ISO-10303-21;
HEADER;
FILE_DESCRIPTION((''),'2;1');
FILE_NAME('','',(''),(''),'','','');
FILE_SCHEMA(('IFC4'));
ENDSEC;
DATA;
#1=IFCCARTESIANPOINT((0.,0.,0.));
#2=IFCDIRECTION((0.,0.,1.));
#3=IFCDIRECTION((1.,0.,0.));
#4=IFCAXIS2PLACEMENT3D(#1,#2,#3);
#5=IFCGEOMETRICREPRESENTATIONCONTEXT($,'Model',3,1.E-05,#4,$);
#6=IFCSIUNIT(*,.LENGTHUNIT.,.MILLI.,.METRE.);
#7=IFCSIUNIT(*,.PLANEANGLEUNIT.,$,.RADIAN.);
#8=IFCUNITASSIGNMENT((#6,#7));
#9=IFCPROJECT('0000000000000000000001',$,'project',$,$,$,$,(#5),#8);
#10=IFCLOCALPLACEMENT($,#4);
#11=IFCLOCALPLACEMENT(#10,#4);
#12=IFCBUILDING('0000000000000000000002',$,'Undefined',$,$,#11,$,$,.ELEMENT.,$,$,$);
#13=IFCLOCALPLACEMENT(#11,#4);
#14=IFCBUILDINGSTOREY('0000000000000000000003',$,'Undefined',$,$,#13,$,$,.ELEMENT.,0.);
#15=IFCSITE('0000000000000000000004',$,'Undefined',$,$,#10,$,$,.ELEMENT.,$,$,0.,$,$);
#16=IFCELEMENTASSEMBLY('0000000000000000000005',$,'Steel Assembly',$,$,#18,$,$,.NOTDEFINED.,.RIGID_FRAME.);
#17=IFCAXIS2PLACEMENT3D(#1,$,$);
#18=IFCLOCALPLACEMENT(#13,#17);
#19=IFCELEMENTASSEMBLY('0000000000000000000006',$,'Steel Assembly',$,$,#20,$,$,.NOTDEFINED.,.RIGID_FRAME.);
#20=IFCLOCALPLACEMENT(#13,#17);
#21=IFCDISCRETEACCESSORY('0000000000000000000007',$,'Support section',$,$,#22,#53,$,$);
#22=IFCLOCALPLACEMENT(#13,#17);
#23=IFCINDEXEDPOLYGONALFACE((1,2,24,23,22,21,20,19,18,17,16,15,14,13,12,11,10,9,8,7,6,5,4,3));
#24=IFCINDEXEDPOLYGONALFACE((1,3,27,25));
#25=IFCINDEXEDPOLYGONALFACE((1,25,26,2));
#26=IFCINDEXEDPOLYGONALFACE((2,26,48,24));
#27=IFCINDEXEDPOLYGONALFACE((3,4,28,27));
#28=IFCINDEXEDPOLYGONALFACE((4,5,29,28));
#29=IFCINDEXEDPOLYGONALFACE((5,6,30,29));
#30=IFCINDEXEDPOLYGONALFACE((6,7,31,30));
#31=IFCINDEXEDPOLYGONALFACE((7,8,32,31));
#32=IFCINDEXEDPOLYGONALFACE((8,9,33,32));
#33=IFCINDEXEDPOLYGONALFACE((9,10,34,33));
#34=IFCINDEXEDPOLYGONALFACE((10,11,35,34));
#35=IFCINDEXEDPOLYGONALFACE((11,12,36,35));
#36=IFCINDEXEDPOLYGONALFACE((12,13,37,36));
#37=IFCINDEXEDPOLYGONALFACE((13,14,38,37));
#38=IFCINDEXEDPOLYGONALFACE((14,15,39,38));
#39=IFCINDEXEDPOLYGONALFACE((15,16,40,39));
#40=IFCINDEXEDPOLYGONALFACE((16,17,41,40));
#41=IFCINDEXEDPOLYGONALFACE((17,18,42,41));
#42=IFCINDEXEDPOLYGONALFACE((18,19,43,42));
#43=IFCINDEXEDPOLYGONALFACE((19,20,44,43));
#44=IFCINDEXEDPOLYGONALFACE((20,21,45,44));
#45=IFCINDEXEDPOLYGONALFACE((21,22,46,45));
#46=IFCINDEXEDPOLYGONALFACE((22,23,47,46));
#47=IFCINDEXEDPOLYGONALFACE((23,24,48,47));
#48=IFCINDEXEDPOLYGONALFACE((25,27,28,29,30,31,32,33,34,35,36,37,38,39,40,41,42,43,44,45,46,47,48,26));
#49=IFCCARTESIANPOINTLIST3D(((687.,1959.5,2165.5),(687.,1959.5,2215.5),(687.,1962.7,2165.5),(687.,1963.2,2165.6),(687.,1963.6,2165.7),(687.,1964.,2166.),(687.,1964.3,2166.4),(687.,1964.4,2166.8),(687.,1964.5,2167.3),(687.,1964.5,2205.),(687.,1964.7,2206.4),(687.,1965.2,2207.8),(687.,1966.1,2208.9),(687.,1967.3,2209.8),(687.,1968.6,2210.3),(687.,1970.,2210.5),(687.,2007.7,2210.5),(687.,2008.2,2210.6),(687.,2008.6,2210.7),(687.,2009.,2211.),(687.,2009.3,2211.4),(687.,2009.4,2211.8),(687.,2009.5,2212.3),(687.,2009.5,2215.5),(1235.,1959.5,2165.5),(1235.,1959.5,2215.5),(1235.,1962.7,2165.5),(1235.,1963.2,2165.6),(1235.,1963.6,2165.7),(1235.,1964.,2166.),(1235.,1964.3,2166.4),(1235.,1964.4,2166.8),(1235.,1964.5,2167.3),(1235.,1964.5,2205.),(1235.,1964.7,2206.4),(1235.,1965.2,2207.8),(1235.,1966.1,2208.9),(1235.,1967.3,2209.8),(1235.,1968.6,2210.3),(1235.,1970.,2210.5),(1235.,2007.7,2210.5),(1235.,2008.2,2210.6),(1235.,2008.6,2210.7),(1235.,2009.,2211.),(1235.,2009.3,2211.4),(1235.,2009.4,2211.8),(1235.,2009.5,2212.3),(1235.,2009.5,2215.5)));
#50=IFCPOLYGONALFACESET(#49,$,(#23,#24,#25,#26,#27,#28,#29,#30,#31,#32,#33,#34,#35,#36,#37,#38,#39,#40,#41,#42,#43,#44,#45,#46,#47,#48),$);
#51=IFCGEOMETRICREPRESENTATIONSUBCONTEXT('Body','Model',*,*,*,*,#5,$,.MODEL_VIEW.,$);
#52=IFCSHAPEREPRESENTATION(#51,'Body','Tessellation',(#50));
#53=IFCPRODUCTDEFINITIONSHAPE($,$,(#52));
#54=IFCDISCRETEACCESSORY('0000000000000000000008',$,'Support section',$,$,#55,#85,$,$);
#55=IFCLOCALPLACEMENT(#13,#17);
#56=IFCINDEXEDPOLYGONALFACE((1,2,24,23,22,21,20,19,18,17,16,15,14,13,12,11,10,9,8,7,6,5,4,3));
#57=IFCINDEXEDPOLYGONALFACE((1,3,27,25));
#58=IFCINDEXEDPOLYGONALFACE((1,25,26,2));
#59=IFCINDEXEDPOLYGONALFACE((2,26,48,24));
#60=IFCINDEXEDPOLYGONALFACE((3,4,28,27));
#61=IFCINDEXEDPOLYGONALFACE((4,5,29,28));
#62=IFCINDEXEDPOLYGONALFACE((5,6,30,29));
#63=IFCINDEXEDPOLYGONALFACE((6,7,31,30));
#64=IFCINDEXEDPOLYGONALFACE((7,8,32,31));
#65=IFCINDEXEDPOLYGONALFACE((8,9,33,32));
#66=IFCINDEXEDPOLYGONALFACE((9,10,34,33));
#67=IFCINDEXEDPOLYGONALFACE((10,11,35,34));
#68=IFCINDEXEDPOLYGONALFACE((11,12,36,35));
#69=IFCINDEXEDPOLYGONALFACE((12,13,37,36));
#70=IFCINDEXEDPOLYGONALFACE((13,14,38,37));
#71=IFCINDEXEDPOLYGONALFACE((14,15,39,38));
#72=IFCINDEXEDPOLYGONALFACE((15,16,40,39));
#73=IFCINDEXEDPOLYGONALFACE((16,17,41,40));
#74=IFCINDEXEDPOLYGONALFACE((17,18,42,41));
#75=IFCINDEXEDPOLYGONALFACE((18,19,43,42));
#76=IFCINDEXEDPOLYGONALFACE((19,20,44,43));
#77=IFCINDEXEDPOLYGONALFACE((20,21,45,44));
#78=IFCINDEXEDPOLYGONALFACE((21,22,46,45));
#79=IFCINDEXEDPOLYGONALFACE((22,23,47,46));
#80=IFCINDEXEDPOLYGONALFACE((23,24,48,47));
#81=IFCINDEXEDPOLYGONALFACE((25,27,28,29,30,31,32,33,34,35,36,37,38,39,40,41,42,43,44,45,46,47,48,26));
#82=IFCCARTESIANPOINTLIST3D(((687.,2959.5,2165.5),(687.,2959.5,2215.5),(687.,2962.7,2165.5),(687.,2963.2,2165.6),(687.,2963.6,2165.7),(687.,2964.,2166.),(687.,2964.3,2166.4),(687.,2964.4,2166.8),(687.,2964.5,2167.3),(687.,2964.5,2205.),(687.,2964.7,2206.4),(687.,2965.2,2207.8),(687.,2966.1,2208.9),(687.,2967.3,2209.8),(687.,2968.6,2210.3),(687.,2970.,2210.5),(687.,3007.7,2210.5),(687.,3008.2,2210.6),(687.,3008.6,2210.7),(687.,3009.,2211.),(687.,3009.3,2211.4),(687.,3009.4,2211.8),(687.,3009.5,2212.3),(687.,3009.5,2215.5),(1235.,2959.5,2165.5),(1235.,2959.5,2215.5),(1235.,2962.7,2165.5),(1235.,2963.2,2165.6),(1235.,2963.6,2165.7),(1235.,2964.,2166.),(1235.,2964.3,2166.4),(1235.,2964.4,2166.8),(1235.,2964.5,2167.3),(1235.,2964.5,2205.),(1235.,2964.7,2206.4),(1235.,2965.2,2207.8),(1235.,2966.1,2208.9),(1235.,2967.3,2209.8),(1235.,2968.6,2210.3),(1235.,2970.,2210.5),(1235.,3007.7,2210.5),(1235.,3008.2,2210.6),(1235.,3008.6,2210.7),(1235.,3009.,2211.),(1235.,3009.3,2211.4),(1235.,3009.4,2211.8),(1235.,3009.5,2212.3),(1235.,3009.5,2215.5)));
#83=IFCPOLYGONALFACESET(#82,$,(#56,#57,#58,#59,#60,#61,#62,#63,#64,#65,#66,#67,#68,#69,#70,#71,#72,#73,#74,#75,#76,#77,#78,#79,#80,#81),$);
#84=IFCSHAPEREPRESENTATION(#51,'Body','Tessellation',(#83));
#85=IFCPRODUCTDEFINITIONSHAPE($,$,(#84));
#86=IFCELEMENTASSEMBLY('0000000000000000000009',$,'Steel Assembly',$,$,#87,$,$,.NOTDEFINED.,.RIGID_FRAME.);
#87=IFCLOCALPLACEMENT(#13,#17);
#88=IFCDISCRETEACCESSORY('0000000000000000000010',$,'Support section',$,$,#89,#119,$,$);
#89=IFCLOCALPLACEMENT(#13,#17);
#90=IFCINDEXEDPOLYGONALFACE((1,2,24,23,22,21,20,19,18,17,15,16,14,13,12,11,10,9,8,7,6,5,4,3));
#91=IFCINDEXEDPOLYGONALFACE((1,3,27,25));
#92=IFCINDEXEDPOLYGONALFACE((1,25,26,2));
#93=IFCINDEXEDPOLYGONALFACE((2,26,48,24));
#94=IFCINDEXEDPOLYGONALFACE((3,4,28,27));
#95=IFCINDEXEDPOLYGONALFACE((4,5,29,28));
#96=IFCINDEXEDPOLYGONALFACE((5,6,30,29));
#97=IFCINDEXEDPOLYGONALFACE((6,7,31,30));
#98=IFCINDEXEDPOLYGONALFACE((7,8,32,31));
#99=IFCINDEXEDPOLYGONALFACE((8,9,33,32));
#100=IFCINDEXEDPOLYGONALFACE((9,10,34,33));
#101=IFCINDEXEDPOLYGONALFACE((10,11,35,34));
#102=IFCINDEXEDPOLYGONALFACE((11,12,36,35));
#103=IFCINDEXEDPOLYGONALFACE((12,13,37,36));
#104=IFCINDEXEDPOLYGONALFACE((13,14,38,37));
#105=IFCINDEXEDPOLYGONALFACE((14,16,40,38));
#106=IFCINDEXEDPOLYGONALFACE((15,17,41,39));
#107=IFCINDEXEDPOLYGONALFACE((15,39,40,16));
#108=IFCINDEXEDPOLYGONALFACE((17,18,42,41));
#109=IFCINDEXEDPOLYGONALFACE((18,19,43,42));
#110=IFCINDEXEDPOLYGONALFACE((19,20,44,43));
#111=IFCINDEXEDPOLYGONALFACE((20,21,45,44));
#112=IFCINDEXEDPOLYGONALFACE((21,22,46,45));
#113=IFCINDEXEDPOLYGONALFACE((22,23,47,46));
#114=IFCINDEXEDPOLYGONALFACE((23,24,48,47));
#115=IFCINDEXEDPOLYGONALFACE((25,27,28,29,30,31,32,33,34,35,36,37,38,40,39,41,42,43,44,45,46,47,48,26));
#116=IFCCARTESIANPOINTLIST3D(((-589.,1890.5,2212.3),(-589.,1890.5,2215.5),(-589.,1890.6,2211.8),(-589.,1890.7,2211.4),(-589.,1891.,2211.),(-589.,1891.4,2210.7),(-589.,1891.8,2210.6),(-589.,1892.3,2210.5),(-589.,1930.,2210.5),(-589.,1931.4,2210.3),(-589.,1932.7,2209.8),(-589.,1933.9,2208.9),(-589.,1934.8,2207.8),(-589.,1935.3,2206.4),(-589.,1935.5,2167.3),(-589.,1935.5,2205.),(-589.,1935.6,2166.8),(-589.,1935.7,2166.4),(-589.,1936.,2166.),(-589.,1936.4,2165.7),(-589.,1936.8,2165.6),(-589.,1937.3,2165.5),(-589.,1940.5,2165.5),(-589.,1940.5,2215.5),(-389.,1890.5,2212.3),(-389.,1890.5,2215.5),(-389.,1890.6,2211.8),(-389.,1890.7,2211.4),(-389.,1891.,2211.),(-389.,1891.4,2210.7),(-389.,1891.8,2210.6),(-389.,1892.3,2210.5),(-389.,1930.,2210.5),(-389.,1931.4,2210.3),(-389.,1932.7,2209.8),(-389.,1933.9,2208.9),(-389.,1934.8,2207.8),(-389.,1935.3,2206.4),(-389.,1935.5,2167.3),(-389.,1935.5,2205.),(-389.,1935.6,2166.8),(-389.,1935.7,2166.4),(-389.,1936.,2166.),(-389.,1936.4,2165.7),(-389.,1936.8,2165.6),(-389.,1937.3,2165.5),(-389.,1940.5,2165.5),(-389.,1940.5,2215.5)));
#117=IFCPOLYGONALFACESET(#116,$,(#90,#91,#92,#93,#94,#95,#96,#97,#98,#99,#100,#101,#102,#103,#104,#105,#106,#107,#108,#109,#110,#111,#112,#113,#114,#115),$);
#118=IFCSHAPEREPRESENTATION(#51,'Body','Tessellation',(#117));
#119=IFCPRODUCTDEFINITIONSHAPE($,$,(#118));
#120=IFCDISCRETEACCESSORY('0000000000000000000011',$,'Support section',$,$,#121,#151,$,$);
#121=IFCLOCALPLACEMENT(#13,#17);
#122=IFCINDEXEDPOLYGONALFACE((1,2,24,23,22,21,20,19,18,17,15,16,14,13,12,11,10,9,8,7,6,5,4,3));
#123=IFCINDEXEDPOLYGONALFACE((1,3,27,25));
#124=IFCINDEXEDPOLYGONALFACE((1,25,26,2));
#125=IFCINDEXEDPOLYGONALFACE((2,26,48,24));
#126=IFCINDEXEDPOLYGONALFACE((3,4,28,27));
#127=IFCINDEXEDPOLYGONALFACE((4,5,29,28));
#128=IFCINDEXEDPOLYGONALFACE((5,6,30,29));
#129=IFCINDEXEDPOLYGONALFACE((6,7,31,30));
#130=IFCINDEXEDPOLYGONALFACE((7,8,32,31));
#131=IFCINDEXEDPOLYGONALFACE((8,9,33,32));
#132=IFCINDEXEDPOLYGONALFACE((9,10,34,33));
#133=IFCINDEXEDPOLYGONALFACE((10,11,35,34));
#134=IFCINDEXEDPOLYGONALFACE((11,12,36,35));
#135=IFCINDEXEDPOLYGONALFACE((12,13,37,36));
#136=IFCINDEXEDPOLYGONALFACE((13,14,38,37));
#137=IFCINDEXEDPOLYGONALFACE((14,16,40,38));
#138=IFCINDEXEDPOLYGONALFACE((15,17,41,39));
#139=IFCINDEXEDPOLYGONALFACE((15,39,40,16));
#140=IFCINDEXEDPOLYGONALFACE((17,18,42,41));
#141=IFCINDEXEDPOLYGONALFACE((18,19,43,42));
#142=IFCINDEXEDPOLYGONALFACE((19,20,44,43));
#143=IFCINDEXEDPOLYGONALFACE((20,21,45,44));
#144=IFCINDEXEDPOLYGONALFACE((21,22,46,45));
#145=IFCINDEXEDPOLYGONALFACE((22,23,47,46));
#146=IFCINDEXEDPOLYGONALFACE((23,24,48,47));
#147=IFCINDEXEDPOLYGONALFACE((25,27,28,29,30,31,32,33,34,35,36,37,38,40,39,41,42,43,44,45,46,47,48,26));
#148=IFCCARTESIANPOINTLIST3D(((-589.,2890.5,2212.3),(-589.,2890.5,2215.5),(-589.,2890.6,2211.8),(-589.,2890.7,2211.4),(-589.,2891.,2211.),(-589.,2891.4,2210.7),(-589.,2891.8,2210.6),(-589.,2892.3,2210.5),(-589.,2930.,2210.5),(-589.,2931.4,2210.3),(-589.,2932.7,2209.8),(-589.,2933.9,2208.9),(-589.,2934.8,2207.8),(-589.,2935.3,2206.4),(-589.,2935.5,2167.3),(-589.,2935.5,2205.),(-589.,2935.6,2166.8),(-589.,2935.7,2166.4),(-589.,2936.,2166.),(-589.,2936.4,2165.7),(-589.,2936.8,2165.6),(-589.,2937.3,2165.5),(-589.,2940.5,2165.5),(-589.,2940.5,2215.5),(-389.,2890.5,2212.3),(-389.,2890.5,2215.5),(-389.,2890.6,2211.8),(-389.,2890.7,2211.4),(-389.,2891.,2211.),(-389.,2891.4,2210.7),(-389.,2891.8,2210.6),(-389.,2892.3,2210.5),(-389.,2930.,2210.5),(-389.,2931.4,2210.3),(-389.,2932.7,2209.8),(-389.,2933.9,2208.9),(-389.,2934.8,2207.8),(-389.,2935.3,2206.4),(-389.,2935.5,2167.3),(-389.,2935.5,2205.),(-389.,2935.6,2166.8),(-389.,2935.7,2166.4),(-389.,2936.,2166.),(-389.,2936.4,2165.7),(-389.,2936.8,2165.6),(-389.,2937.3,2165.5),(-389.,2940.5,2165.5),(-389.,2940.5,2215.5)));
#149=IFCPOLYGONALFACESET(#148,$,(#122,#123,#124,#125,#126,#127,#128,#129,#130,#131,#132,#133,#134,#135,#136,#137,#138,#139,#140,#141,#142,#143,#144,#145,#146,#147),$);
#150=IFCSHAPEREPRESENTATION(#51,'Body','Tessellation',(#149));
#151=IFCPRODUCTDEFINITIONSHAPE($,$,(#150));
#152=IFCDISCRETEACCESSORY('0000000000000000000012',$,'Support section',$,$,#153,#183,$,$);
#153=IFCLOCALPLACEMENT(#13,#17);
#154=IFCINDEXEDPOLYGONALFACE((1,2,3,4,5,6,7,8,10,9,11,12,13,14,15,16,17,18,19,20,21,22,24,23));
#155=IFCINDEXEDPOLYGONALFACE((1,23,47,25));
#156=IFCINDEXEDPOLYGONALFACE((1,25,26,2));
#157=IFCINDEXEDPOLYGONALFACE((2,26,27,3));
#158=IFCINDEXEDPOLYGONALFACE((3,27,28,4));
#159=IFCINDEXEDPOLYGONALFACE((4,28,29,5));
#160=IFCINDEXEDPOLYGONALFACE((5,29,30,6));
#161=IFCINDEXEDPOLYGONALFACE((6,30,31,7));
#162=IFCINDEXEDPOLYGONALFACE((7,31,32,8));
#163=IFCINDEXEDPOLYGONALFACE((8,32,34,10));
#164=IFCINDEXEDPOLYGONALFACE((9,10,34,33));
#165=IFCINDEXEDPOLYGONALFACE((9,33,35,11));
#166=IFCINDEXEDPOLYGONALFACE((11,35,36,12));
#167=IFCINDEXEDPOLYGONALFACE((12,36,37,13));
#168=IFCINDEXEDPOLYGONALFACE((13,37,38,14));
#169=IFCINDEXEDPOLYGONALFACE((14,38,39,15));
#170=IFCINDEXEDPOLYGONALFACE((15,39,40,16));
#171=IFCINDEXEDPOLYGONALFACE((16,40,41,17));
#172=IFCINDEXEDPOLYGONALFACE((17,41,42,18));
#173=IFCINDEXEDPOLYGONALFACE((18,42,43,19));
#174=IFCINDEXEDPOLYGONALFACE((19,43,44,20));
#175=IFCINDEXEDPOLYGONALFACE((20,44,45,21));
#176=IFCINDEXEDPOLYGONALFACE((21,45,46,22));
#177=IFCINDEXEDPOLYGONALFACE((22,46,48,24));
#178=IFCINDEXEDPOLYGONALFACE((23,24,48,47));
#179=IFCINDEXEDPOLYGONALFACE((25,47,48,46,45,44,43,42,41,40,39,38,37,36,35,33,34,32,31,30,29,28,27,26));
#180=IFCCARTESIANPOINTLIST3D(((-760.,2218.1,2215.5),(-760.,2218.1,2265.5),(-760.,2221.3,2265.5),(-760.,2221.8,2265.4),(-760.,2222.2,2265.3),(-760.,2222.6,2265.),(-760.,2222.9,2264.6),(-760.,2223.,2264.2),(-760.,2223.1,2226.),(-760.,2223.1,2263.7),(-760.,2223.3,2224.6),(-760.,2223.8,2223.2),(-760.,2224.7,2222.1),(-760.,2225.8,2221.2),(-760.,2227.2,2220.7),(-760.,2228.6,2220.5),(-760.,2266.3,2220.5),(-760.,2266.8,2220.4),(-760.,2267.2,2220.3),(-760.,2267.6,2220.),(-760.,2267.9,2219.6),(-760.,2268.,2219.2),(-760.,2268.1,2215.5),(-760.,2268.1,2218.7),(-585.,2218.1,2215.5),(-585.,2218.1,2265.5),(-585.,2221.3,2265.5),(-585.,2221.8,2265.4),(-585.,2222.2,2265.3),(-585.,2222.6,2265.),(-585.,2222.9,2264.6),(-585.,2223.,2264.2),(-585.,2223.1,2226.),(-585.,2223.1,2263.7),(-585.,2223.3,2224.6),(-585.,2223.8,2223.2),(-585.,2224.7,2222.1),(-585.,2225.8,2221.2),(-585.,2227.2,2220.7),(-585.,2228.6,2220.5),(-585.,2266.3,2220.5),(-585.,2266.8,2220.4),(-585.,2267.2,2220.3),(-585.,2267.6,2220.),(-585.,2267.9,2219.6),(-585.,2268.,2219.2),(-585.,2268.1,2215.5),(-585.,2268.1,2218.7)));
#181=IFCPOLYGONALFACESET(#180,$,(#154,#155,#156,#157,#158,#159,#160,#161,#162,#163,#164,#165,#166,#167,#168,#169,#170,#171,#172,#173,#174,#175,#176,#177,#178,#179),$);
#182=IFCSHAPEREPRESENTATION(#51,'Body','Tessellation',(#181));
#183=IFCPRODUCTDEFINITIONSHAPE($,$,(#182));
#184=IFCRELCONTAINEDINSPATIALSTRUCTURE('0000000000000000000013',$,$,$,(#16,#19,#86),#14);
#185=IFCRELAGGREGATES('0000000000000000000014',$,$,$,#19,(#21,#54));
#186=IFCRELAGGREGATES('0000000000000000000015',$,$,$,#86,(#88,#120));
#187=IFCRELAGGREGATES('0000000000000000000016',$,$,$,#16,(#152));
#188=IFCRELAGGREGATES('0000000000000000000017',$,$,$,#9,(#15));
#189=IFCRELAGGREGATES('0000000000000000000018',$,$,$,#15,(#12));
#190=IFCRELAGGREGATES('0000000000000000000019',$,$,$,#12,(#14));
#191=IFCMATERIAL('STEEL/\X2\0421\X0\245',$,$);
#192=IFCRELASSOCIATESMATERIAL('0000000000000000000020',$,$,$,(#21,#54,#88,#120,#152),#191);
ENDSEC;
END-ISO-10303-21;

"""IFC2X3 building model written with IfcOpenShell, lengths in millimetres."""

from ifc_helpers import new_model, si_unit, frame, origin_with_axes, origin_2d_with_axis, place, context, subcontext, project, spatial, l_section, extrude, material, element, aggregate, save


model = new_model("IFC2X3")

# Units and contexts
model_context = context("Model", 3, precision=1e-05, world=origin_with_axes())
body_context = subcontext(model_context, "Body", "Model", "MODEL_VIEW")
ifc_project = project(units=[si_unit("LENGTHUNIT", "METRE", prefix="MILLI"), si_unit("PLANEANGLEUNIT", "RADIAN")], contexts=[model_context])

# Site, building, storey
site_placement = place(None, origin_with_axes())
site = spatial("IfcSite", under=ifc_project, at=site_placement, Name="Undefined", CompositionType="ELEMENT", RefElevation=0.0)
building_placement = place(site_placement, origin_with_axes())
building = spatial("IfcBuilding", under=site, at=building_placement, Name="Undefined", CompositionType="ELEMENT")
storey_placement = place(building_placement, origin_with_axes())
storey = spatial("IfcBuildingStorey", under=building, at=storey_placement, Name="Undefined", CompositionType="ELEMENT", Elevation=0.0)

# Shared definitions
ifc_material_1 = material(Name="STEEL/С245")

# Element assembly
assembly_1_placement = place(storey_placement, origin_with_axes())
assembly_1 = element("IfcElementAssembly", 1, at=assembly_1_placement, inside=storey, Name="Steel Assembly", AssemblyPlace="NOTDEFINED", PredefinedType="RIGID_FRAME")

# Element assembly
assembly_2_placement = place(storey_placement, origin_with_axes())
assembly_2 = element("IfcElementAssembly", 2, at=assembly_2_placement, inside=storey, Name="Steel Assembly", AssemblyPlace="NOTDEFINED", PredefinedType="RIGID_FRAME")

# Discrete accessories
discrete_accessory_1_placement = place(assembly_2_placement, frame((1235.0, 1984.5, 2190.5), z_axis=(0.0, 1.0, 0.0), x_axis=(-1.0, 0.0, 0.0)))
discrete_accessory_1 = element("IfcDiscreteAccessory", 3, at=discrete_accessory_1_placement, material=ifc_material_1, Name="Support section", context=body_context, shape_type="SweptSolid", body=[
    extrude(l_section(Depth=50.0, Width=50.0, Thickness=5.0, FilletRadius=5.5, EdgeRadius=1.8, at=origin_2d_with_axis()), frame((548.0, 0.0, 0.0), z_axis=(-1.0, 0.0, 0.0), x_axis=(0.0, -1.0, 0.0)), (0.0, 0.0, 1.0), 548.0),
])
discrete_accessory_2_placement = place(assembly_2_placement, frame((1235.0, 2984.5, 2190.5), z_axis=(0.0, 1.0, 0.0), x_axis=(-1.0, 0.0, 0.0)))
discrete_accessory_2 = element("IfcDiscreteAccessory", 4, at=discrete_accessory_2_placement, material=ifc_material_1, Name="Support section", context=body_context, shape_type="SweptSolid", body=[
    extrude(l_section(Depth=50.0, Width=50.0, Thickness=5.0, FilletRadius=5.5, EdgeRadius=1.8, at=origin_2d_with_axis()), frame((548.0, 0.0, 0.0), z_axis=(-1.0, 0.0, 0.0), x_axis=(0.0, -1.0, 0.0)), (0.0, 0.0, 1.0), 548.0),
])
aggregate(assembly_2, [discrete_accessory_1, discrete_accessory_2])

# Element assembly, discrete accessories
assembly_3_placement = place(storey_placement, origin_with_axes())
assembly_3 = element("IfcElementAssembly", 5, at=assembly_3_placement, inside=storey, Name="Steel Assembly", AssemblyPlace="NOTDEFINED", PredefinedType="RIGID_FRAME")
discrete_accessory_3_placement = place(assembly_3_placement, frame((-589.0, 1915.5, 2190.5), z_axis=(0.0, -1.0, 0.0), x_axis=(1.0, 0.0, 0.0)))
discrete_accessory_3 = element("IfcDiscreteAccessory", 6, at=discrete_accessory_3_placement, material=ifc_material_1, Name="Support section", context=body_context, shape_type="SweptSolid", body=[
    extrude(l_section(Depth=50.0, Width=50.0, Thickness=5.0, FilletRadius=5.5, EdgeRadius=1.8, at=origin_2d_with_axis()), frame((200.0, 0.0, 0.0), z_axis=(-1.0, 0.0, 0.0), x_axis=(0.0, -1.0, 0.0)), (0.0, 0.0, 1.0), 200.0),
])
discrete_accessory_4_placement = place(assembly_3_placement, frame((-589.0, 2915.5, 2190.5), z_axis=(0.0, -1.0, 0.0), x_axis=(1.0, 0.0, 0.0)))
discrete_accessory_4 = element("IfcDiscreteAccessory", 7, at=discrete_accessory_4_placement, material=ifc_material_1, Name="Support section", context=body_context, shape_type="SweptSolid", body=[
    extrude(l_section(Depth=50.0, Width=50.0, Thickness=5.0, FilletRadius=5.5, EdgeRadius=1.8, at=origin_2d_with_axis()), frame((200.0, 0.0, 0.0), z_axis=(-1.0, 0.0, 0.0), x_axis=(0.0, -1.0, 0.0)), (0.0, 0.0, 1.0), 200.0),
])
aggregate(assembly_3, [discrete_accessory_3, discrete_accessory_4])

# Discrete accessory
discrete_accessory_5_placement = place(assembly_1_placement, frame((-760.0, 2243.1, 2240.5), z_axis=(0.0, 1.0, 0.0), x_axis=(1.0, 0.0, 0.0)))
discrete_accessory_5 = element("IfcDiscreteAccessory", 8, at=discrete_accessory_5_placement, material=ifc_material_1, Name="Support section", context=body_context, shape_type="SweptSolid", body=[
    extrude(l_section(Depth=50.0, Width=50.0, Thickness=5.0, FilletRadius=5.5, EdgeRadius=1.8, at=origin_2d_with_axis()), frame((175.0, 0.0, 0.0), z_axis=(-1.0, 0.0, 0.0), x_axis=(0.0, -1.0, 0.0)), (0.0, 0.0, 1.0), 175.0),
])
aggregate(assembly_1, [discrete_accessory_5])

save(model, "model.ifc")
